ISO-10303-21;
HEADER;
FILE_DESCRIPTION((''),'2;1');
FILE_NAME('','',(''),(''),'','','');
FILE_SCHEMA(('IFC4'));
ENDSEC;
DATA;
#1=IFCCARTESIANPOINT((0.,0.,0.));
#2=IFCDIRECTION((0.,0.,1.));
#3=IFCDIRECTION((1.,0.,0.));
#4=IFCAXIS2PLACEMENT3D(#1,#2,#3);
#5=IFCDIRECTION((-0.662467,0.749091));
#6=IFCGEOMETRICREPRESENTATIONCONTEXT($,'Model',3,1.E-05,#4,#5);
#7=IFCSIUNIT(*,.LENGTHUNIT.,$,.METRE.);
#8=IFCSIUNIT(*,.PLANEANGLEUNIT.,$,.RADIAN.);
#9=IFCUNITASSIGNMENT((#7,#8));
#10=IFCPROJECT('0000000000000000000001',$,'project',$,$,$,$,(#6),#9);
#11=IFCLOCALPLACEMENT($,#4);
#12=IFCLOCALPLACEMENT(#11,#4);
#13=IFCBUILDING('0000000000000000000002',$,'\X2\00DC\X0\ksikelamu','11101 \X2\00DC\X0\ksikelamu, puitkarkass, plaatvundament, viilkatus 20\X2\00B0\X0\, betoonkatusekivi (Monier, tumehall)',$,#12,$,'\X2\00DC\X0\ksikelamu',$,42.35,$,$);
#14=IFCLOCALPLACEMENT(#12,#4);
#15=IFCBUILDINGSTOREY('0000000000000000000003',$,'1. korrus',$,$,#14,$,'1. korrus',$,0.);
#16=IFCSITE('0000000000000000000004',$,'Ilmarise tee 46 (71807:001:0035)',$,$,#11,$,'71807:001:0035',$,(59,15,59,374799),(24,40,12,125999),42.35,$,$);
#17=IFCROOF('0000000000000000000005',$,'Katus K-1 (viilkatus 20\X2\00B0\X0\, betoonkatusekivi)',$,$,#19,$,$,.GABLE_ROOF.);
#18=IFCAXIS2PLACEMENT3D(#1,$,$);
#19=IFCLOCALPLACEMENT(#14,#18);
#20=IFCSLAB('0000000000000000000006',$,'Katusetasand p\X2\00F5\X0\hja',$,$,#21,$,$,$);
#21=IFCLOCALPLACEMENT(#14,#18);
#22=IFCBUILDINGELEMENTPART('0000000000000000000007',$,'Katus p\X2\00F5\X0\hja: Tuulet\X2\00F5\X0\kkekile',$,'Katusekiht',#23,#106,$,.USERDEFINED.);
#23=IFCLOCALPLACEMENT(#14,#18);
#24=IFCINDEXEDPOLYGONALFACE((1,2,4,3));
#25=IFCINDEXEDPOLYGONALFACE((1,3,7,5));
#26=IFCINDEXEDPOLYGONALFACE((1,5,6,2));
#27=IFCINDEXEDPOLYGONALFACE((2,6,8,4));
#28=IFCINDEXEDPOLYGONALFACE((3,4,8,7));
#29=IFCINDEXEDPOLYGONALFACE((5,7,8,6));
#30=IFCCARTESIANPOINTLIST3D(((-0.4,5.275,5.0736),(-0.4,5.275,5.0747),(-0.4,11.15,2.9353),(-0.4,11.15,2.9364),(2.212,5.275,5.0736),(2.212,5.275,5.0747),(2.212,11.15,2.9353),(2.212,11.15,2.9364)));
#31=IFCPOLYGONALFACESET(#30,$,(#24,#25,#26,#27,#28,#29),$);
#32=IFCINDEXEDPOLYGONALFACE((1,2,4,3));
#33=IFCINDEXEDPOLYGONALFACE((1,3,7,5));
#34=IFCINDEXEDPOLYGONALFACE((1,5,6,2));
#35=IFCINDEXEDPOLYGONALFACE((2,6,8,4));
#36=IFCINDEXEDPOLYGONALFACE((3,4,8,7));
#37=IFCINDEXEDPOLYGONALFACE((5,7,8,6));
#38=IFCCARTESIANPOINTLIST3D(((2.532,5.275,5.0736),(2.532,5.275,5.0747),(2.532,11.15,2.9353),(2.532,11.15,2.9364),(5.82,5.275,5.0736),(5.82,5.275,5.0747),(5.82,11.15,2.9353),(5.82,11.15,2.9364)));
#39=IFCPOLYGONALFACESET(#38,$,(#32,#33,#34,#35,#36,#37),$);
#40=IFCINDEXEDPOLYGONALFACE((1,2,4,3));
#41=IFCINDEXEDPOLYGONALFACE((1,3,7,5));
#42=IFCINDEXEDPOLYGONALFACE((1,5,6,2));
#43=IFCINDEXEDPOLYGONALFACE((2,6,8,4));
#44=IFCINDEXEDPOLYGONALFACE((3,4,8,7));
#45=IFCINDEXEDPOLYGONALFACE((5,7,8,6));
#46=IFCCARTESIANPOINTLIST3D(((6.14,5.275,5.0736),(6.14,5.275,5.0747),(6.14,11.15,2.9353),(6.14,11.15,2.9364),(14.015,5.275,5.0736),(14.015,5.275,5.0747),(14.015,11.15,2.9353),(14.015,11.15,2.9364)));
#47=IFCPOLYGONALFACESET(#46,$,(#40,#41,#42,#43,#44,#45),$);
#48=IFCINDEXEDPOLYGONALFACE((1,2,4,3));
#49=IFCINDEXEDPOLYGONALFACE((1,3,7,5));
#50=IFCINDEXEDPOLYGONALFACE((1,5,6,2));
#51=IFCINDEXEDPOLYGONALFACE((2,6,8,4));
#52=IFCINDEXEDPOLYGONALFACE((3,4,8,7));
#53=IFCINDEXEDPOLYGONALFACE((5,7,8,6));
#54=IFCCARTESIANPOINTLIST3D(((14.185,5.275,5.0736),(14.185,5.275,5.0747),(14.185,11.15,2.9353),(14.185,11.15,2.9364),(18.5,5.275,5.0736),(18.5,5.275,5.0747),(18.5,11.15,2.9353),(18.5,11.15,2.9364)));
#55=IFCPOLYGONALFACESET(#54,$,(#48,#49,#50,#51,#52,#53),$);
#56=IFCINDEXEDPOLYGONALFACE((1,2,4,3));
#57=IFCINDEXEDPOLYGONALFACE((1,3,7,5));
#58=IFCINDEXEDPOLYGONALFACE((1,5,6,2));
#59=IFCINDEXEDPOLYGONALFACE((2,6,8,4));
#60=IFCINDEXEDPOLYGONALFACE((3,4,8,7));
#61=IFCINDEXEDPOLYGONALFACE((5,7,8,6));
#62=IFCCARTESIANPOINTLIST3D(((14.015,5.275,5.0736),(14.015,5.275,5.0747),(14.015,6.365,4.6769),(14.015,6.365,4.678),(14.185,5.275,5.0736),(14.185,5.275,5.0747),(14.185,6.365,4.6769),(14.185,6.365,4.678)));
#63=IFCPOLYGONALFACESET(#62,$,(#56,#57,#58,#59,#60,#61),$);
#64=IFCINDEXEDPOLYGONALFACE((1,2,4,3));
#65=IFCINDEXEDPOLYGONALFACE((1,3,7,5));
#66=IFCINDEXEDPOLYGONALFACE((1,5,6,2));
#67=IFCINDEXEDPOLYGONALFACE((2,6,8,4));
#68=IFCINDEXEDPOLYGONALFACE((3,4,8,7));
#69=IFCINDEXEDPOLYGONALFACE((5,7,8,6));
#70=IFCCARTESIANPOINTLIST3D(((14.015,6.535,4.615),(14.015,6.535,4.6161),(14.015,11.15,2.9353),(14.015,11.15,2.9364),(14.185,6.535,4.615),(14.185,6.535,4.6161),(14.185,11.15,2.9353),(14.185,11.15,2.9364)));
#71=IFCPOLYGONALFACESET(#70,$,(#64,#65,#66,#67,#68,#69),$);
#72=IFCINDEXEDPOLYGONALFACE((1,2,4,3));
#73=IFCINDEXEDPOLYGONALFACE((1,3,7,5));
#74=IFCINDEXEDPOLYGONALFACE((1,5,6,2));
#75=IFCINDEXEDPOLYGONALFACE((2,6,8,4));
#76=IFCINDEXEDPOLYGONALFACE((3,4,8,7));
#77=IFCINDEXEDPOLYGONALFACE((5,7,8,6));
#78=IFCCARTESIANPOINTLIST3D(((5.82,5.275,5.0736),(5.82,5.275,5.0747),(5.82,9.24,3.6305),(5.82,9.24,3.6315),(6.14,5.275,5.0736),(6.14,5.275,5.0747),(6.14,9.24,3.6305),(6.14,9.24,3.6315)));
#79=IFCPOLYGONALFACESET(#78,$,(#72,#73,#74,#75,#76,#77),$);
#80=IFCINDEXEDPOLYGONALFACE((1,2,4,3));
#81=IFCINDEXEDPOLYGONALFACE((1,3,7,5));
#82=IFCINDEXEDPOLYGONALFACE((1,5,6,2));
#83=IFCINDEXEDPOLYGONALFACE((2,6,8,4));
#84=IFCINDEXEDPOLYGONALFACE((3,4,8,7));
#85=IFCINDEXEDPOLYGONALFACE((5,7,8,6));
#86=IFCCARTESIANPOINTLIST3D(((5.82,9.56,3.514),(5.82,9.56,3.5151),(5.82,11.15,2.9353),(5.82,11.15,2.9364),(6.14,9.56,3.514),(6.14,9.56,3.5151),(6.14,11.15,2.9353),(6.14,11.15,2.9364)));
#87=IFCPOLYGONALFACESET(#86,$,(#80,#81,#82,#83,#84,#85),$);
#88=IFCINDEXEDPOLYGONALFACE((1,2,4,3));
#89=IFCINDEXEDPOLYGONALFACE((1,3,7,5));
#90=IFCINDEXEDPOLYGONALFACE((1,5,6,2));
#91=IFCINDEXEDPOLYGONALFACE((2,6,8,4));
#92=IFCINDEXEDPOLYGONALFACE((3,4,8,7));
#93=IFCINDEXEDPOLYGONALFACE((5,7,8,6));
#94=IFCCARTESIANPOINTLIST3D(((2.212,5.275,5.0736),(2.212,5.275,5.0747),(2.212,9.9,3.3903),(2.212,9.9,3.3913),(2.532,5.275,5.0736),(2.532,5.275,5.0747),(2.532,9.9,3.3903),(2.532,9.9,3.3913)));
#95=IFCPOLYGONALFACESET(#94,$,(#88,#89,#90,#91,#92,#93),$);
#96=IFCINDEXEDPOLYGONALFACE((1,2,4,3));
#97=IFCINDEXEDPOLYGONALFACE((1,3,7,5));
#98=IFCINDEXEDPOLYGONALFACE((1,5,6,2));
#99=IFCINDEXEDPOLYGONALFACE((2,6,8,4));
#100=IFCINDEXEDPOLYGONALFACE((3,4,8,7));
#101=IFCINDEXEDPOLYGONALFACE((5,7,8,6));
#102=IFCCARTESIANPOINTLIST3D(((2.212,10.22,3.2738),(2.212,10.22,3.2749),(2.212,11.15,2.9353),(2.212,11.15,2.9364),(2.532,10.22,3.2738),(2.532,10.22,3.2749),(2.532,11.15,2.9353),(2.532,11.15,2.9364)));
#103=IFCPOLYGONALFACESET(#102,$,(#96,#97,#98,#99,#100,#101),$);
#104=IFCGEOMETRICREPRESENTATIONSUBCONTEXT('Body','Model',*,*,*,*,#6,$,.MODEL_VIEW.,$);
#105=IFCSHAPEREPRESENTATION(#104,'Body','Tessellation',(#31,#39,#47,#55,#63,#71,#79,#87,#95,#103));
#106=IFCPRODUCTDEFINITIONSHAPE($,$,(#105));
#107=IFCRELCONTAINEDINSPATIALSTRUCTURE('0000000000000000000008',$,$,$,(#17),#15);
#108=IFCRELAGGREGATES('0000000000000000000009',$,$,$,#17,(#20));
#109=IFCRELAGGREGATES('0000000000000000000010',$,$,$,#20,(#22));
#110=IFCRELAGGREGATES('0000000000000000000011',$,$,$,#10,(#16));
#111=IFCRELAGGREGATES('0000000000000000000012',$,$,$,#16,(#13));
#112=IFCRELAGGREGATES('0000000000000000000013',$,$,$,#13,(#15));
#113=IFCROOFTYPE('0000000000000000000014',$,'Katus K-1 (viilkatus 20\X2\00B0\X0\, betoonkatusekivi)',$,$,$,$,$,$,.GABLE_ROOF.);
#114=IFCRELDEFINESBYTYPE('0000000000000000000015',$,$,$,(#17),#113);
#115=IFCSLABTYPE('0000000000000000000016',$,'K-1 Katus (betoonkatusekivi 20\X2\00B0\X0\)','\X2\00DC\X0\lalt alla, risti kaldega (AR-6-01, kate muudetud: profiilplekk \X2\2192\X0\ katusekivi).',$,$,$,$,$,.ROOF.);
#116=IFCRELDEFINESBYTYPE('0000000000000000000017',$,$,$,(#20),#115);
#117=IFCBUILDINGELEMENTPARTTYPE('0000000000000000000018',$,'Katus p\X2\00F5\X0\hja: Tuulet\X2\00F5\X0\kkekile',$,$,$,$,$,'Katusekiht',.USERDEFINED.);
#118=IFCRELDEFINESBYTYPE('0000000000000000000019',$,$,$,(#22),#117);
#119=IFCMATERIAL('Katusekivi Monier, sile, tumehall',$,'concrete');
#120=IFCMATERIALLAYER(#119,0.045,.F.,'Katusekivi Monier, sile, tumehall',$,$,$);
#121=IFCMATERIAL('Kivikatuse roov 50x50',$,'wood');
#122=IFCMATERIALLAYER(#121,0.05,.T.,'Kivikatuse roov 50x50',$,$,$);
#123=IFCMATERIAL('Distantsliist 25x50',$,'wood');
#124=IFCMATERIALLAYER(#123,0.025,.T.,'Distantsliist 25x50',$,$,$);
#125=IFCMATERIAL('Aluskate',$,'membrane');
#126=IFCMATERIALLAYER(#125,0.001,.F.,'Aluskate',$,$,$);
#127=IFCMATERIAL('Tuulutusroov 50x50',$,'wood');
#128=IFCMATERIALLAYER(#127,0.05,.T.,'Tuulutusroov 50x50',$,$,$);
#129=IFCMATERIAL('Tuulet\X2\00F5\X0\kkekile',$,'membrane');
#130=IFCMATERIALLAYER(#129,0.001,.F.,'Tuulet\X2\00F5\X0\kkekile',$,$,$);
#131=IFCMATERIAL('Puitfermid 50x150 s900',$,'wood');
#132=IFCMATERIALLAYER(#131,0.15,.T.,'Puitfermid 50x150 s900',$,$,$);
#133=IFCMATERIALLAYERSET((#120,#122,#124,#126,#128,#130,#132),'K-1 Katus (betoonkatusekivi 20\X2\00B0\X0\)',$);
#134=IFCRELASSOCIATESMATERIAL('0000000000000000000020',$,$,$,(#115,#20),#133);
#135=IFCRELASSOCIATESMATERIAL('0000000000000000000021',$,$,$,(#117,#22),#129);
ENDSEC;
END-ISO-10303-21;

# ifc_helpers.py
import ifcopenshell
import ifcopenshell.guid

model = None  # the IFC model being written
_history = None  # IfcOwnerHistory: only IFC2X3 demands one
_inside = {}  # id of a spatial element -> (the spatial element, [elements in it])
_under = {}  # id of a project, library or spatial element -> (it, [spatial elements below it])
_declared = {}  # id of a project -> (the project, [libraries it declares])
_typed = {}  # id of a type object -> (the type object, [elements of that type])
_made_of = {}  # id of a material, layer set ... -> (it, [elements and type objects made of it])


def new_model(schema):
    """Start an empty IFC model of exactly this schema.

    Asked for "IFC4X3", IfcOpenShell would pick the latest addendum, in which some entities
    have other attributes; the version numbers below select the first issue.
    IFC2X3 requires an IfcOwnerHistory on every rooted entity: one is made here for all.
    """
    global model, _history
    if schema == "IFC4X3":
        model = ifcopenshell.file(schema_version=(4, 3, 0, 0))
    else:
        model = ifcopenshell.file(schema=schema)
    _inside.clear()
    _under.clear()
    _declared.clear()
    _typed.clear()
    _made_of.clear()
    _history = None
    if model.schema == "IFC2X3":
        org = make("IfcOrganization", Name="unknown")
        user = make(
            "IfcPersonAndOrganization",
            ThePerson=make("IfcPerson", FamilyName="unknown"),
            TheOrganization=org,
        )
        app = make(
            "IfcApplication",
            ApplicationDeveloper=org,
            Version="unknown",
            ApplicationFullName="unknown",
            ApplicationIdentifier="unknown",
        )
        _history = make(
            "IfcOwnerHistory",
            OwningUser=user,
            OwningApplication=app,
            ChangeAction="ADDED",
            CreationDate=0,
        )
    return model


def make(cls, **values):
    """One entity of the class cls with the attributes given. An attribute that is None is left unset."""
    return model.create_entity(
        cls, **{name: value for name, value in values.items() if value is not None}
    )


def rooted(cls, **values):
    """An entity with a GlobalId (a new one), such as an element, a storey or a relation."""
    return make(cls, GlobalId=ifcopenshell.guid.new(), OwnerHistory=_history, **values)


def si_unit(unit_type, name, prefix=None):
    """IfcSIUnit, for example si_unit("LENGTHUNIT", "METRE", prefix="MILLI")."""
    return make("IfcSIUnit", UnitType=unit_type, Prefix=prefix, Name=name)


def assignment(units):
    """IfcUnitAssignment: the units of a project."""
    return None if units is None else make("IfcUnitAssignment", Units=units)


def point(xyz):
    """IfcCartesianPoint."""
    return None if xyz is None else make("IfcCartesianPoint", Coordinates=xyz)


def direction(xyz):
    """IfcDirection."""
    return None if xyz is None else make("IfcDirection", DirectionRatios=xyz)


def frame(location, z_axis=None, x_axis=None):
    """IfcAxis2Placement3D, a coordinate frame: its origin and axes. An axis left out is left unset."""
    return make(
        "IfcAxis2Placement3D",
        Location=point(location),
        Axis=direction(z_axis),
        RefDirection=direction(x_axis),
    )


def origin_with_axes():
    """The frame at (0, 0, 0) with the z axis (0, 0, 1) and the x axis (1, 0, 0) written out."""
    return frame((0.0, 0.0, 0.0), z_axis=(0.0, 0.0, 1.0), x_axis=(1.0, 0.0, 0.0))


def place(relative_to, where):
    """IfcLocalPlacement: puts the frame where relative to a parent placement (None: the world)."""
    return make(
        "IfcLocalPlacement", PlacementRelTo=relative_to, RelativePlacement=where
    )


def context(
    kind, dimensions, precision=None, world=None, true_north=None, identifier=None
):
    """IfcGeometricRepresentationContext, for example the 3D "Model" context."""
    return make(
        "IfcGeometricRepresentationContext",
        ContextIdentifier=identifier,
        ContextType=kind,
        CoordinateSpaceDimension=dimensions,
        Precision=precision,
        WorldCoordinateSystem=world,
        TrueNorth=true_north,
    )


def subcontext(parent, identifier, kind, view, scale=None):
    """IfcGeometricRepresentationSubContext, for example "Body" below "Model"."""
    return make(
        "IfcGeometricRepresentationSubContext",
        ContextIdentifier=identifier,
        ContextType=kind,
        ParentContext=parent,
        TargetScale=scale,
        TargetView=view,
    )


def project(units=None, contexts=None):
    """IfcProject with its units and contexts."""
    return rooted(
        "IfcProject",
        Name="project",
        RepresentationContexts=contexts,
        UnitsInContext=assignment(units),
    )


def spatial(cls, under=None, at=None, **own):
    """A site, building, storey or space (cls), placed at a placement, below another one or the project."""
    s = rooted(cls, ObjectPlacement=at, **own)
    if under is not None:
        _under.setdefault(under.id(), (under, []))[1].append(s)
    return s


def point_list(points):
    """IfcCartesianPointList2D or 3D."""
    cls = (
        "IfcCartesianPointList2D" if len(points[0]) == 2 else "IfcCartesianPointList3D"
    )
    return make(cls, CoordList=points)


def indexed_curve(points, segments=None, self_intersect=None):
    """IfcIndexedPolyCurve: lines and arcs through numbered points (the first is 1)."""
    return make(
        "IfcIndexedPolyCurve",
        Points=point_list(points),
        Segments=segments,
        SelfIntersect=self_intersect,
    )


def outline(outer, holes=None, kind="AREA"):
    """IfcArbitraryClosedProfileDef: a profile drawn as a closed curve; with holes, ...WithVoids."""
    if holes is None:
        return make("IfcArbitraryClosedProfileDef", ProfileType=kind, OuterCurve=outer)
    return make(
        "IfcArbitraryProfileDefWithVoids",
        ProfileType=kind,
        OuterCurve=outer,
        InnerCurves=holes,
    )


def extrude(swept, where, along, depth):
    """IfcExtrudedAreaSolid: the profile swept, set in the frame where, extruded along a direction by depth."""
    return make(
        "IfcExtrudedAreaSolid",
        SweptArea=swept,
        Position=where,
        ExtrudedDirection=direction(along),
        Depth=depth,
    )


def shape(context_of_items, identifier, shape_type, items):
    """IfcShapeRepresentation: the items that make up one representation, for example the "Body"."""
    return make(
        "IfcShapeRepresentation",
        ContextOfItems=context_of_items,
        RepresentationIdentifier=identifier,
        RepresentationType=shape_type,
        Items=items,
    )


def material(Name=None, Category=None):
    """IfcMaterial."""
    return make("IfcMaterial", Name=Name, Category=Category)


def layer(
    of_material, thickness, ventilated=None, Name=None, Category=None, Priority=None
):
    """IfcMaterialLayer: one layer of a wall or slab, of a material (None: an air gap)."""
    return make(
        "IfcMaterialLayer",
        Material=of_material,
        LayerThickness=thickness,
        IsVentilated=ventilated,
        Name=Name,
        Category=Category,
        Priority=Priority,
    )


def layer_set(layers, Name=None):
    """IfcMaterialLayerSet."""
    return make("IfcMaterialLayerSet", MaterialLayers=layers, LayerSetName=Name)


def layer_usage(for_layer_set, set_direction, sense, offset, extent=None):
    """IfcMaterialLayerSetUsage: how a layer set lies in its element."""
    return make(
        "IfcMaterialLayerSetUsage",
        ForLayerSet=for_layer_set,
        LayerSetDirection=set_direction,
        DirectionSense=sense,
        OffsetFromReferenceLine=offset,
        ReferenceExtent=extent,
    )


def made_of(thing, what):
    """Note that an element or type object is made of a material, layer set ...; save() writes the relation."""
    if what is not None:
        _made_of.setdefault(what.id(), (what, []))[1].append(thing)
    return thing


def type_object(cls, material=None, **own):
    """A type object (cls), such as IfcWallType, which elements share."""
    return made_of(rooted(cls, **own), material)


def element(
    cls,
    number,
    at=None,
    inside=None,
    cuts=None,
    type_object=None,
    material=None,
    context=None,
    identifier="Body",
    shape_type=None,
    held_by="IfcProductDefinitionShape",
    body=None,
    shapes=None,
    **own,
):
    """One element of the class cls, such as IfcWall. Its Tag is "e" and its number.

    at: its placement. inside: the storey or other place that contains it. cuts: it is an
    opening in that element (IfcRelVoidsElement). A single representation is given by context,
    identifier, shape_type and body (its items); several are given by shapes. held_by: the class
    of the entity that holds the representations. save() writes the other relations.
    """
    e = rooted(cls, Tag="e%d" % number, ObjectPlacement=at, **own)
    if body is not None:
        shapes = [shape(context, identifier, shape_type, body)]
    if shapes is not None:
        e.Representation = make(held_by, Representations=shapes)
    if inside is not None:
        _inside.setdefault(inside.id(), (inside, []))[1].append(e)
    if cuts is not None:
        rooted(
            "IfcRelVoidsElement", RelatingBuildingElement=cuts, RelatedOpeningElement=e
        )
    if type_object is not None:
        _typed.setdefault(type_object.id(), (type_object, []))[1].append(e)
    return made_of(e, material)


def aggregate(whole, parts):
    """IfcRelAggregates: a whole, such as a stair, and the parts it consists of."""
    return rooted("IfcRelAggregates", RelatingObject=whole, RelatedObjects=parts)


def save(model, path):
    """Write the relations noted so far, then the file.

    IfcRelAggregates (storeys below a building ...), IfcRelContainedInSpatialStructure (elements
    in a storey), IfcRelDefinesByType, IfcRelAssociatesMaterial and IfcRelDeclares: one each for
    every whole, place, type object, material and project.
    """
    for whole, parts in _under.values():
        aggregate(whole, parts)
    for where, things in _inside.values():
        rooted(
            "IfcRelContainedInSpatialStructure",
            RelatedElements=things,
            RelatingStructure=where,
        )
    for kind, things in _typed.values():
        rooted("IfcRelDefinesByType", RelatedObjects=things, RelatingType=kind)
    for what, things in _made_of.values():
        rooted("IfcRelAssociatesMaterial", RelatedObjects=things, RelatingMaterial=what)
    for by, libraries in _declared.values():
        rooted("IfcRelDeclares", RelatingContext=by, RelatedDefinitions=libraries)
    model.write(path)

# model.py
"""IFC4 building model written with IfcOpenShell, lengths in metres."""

from ifc_helpers import new_model, si_unit, direction, frame, origin_with_axes, place, context, subcontext, project, spatial, indexed_curve, outline, extrude, material, layer, layer_set, layer_usage, type_object, element, aggregate, save


model = new_model("IFC4")

# Units and contexts
model_context = context("Model", 3, precision=1e-05, world=origin_with_axes(), true_north=direction((-0.662467, 0.749091)))
body_context = subcontext(model_context, "Body", "Model", "MODEL_VIEW")
ifc_project = project(units=[si_unit("LENGTHUNIT", "METRE"), si_unit("PLANEANGLEUNIT", "RADIAN")], contexts=[model_context])

# Site, building, storey
site_placement = place(None, origin_with_axes())
site = spatial("IfcSite", under=ifc_project, at=site_placement, Name="Ilmarise tee 46 (71807:001:0035)", LongName="71807:001:0035", RefLatitude=(59, 15, 59, 374799), RefLongitude=(24, 40, 12, 125999), RefElevation=42.35)
building_placement = place(site_placement, origin_with_axes())
building = spatial("IfcBuilding", under=site, at=building_placement, Name="Üksikelamu", Description="11101 Üksikelamu, puitkarkass, plaatvundament, viilkatus 20°, betoonkatusekivi (Monier, tumehall)", LongName="Üksikelamu", ElevationOfRefHeight=42.35)
storey_placement = place(building_placement, origin_with_axes())
storey = spatial("IfcBuildingStorey", under=building, at=storey_placement, Name="1. korrus", LongName="1. korrus", Elevation=0.0)

# Roof
roof_type = type_object("IfcRoofType", Name="Katus K-1 (viilkatus 20°, betoonkatusekivi)", PredefinedType="GABLE_ROOF")
roof_placement = place(storey_placement, origin_with_axes())
roof = element("IfcRoof", 1, at=roof_placement, inside=storey, type_object=roof_type, Name="Katus K-1 (viilkatus 20°, betoonkatusekivi)", PredefinedType="GABLE_ROOF")

# Shared definitions
ifc_material_1 = material(Name="Katusekivi Monier, sile, tumehall", Category="concrete")
ifc_layer_1 = layer(ifc_material_1, 0.045, ventilated=False, Name="Katusekivi Monier, sile, tumehall")
ifc_material_2 = material(Name="Kivikatuse roov 50x50", Category="wood")
ifc_layer_2 = layer(ifc_material_2, 0.05, ventilated=True, Name="Kivikatuse roov 50x50")
ifc_material_3 = material(Name="Distantsliist 25x50", Category="wood")
ifc_layer_3 = layer(ifc_material_3, 0.025, ventilated=True, Name="Distantsliist 25x50")
ifc_material_4 = material(Name="Aluskate", Category="membrane")
ifc_layer_4 = layer(ifc_material_4, 0.001, ventilated=False, Name="Aluskate")
ifc_material_5 = material(Name="Tuulutusroov 50x50", Category="wood")
ifc_layer_5 = layer(ifc_material_5, 0.05, ventilated=True, Name="Tuulutusroov 50x50")
ifc_material_6 = material(Name="Tuuletõkkekile", Category="membrane")
ifc_layer_6 = layer(ifc_material_6, 0.001, ventilated=False, Name="Tuuletõkkekile")
ifc_material_7 = material(Name="Puitfermid 50x150 s900", Category="wood")
ifc_layer_7 = layer(ifc_material_7, 0.15, ventilated=True, Name="Puitfermid 50x150 s900")
ifc_layer_set = layer_set([ifc_layer_1, ifc_layer_2, ifc_layer_3, ifc_layer_4, ifc_layer_5, ifc_layer_6, ifc_layer_7], Name="K-1 Katus (betoonkatusekivi 20°)")
slab_type = type_object("IfcSlabType", Name="K-1 Katus (betoonkatusekivi 20°)", Description="Ülalt alla, risti kaldega (AR-6-01, kate muudetud: profiilplekk → katusekivi).", PredefinedType="ROOF", material=ifc_layer_set)

# Slab
ifc_layer_usage_1 = layer_usage(ifc_layer_set, "AXIS3", "POSITIVE", 0.0)
slab_1_placement = place(roof_placement, origin_with_axes())
slab_1 = element("IfcSlab", 2, at=slab_1_placement, type_object=slab_type, material=ifc_layer_usage_1, Name="Katusetasand põhja")
aggregate(roof, [slab_1])

# Building element part
building_element_part_type_1 = type_object("IfcBuildingElementPartType", Name="Katus põhja: Tuuletõkkekile", ElementType="Katusekiht", PredefinedType="USERDEFINED", material=ifc_material_6)
building_element_part_1_placement = place(slab_1_placement, origin_with_axes())
building_element_part_1 = element("IfcBuildingElementPart", 3, at=building_element_part_1_placement, type_object=building_element_part_type_1, material=ifc_material_6, Name="Katus põhja: Tuuletõkkekile", ObjectType="Katusekiht", PredefinedType="USERDEFINED", context=body_context, shape_type="SweptSolid", body=[
    extrude(outline(indexed_curve([(5.275, 5.0736), (11.15, 2.9353), (11.15, 2.9364), (5.275, 5.0747), (5.275, 5.0736)], self_intersect=False)), frame((-0.4, 0.0, 0.0), z_axis=(1.0, 0.0, 0.0), x_axis=(0.0, 1.0, 0.0)), (0.0, 0.0, 1.0), 2.612),
    extrude(outline(indexed_curve([(5.275, 5.0736), (11.15, 2.9353), (11.15, 2.9364), (5.275, 5.0747), (5.275, 5.0736)], self_intersect=False)), frame((2.532, 0.0, 0.0), z_axis=(1.0, 0.0, 0.0), x_axis=(0.0, 1.0, 0.0)), (0.0, 0.0, 1.0), 3.288),
    extrude(outline(indexed_curve([(5.275, 5.0736), (11.15, 2.9353), (11.15, 2.9364), (5.275, 5.0747), (5.275, 5.0736)], self_intersect=False)), frame((6.14, 0.0, 0.0), z_axis=(1.0, 0.0, 0.0), x_axis=(0.0, 1.0, 0.0)), (0.0, 0.0, 1.0), 7.875),
    extrude(outline(indexed_curve([(5.275, 5.0736), (11.15, 2.9353), (11.15, 2.9364), (5.275, 5.0747), (5.275, 5.0736)], self_intersect=False)), frame((14.185, 0.0, 0.0), z_axis=(1.0, 0.0, 0.0), x_axis=(0.0, 1.0, 0.0)), (0.0, 0.0, 1.0), 4.315),
    extrude(outline(indexed_curve([(5.275, 5.0736), (5.275, 5.0747), (6.365, 4.678), (6.365, 4.6769), (5.275, 5.0736)], self_intersect=False)), frame((14.015, 0.0, 0.0), z_axis=(1.0, 0.0, 0.0), x_axis=(0.0, 1.0, 0.0)), (0.0, 0.0, 1.0), 0.17),
    extrude(outline(indexed_curve([(11.15, 2.9364), (11.15, 2.9353), (6.535, 4.615), (6.535, 4.6161), (11.15, 2.9364)], self_intersect=False)), frame((14.015, 0.0, 0.0), z_axis=(1.0, 0.0, 0.0), x_axis=(0.0, 1.0, 0.0)), (0.0, 0.0, 1.0), 0.17),
    extrude(outline(indexed_curve([(5.275, 5.0736), (5.275, 5.0747), (9.24, 3.6315), (9.24, 3.6305), (5.275, 5.0736)], self_intersect=False)), frame((5.82, 0.0, 0.0), z_axis=(1.0, 0.0, 0.0), x_axis=(0.0, 1.0, 0.0)), (0.0, 0.0, 1.0), 0.32),
    extrude(outline(indexed_curve([(11.15, 2.9364), (11.15, 2.9353), (9.56, 3.514), (9.56, 3.5151), (11.15, 2.9364)], self_intersect=False)), frame((5.82, 0.0, 0.0), z_axis=(1.0, 0.0, 0.0), x_axis=(0.0, 1.0, 0.0)), (0.0, 0.0, 1.0), 0.32),
    extrude(outline(indexed_curve([(5.275, 5.0736), (5.275, 5.0747), (9.9, 3.3913), (9.9, 3.3903), (5.275, 5.0736)], self_intersect=False)), frame((2.212, 0.0, 0.0), z_axis=(1.0, 0.0, 0.0), x_axis=(0.0, 1.0, 0.0)), (0.0, 0.0, 1.0), 0.32),
    extrude(outline(indexed_curve([(11.15, 2.9364), (11.15, 2.9353), (10.22, 3.2738), (10.22, 3.2749), (11.15, 2.9364)], self_intersect=False)), frame((2.212, 0.0, 0.0), z_axis=(1.0, 0.0, 0.0), x_axis=(0.0, 1.0, 0.0)), (0.0, 0.0, 1.0), 0.32),
])
aggregate(slab_1, [building_element_part_1])

save(model, "model.ifc")
